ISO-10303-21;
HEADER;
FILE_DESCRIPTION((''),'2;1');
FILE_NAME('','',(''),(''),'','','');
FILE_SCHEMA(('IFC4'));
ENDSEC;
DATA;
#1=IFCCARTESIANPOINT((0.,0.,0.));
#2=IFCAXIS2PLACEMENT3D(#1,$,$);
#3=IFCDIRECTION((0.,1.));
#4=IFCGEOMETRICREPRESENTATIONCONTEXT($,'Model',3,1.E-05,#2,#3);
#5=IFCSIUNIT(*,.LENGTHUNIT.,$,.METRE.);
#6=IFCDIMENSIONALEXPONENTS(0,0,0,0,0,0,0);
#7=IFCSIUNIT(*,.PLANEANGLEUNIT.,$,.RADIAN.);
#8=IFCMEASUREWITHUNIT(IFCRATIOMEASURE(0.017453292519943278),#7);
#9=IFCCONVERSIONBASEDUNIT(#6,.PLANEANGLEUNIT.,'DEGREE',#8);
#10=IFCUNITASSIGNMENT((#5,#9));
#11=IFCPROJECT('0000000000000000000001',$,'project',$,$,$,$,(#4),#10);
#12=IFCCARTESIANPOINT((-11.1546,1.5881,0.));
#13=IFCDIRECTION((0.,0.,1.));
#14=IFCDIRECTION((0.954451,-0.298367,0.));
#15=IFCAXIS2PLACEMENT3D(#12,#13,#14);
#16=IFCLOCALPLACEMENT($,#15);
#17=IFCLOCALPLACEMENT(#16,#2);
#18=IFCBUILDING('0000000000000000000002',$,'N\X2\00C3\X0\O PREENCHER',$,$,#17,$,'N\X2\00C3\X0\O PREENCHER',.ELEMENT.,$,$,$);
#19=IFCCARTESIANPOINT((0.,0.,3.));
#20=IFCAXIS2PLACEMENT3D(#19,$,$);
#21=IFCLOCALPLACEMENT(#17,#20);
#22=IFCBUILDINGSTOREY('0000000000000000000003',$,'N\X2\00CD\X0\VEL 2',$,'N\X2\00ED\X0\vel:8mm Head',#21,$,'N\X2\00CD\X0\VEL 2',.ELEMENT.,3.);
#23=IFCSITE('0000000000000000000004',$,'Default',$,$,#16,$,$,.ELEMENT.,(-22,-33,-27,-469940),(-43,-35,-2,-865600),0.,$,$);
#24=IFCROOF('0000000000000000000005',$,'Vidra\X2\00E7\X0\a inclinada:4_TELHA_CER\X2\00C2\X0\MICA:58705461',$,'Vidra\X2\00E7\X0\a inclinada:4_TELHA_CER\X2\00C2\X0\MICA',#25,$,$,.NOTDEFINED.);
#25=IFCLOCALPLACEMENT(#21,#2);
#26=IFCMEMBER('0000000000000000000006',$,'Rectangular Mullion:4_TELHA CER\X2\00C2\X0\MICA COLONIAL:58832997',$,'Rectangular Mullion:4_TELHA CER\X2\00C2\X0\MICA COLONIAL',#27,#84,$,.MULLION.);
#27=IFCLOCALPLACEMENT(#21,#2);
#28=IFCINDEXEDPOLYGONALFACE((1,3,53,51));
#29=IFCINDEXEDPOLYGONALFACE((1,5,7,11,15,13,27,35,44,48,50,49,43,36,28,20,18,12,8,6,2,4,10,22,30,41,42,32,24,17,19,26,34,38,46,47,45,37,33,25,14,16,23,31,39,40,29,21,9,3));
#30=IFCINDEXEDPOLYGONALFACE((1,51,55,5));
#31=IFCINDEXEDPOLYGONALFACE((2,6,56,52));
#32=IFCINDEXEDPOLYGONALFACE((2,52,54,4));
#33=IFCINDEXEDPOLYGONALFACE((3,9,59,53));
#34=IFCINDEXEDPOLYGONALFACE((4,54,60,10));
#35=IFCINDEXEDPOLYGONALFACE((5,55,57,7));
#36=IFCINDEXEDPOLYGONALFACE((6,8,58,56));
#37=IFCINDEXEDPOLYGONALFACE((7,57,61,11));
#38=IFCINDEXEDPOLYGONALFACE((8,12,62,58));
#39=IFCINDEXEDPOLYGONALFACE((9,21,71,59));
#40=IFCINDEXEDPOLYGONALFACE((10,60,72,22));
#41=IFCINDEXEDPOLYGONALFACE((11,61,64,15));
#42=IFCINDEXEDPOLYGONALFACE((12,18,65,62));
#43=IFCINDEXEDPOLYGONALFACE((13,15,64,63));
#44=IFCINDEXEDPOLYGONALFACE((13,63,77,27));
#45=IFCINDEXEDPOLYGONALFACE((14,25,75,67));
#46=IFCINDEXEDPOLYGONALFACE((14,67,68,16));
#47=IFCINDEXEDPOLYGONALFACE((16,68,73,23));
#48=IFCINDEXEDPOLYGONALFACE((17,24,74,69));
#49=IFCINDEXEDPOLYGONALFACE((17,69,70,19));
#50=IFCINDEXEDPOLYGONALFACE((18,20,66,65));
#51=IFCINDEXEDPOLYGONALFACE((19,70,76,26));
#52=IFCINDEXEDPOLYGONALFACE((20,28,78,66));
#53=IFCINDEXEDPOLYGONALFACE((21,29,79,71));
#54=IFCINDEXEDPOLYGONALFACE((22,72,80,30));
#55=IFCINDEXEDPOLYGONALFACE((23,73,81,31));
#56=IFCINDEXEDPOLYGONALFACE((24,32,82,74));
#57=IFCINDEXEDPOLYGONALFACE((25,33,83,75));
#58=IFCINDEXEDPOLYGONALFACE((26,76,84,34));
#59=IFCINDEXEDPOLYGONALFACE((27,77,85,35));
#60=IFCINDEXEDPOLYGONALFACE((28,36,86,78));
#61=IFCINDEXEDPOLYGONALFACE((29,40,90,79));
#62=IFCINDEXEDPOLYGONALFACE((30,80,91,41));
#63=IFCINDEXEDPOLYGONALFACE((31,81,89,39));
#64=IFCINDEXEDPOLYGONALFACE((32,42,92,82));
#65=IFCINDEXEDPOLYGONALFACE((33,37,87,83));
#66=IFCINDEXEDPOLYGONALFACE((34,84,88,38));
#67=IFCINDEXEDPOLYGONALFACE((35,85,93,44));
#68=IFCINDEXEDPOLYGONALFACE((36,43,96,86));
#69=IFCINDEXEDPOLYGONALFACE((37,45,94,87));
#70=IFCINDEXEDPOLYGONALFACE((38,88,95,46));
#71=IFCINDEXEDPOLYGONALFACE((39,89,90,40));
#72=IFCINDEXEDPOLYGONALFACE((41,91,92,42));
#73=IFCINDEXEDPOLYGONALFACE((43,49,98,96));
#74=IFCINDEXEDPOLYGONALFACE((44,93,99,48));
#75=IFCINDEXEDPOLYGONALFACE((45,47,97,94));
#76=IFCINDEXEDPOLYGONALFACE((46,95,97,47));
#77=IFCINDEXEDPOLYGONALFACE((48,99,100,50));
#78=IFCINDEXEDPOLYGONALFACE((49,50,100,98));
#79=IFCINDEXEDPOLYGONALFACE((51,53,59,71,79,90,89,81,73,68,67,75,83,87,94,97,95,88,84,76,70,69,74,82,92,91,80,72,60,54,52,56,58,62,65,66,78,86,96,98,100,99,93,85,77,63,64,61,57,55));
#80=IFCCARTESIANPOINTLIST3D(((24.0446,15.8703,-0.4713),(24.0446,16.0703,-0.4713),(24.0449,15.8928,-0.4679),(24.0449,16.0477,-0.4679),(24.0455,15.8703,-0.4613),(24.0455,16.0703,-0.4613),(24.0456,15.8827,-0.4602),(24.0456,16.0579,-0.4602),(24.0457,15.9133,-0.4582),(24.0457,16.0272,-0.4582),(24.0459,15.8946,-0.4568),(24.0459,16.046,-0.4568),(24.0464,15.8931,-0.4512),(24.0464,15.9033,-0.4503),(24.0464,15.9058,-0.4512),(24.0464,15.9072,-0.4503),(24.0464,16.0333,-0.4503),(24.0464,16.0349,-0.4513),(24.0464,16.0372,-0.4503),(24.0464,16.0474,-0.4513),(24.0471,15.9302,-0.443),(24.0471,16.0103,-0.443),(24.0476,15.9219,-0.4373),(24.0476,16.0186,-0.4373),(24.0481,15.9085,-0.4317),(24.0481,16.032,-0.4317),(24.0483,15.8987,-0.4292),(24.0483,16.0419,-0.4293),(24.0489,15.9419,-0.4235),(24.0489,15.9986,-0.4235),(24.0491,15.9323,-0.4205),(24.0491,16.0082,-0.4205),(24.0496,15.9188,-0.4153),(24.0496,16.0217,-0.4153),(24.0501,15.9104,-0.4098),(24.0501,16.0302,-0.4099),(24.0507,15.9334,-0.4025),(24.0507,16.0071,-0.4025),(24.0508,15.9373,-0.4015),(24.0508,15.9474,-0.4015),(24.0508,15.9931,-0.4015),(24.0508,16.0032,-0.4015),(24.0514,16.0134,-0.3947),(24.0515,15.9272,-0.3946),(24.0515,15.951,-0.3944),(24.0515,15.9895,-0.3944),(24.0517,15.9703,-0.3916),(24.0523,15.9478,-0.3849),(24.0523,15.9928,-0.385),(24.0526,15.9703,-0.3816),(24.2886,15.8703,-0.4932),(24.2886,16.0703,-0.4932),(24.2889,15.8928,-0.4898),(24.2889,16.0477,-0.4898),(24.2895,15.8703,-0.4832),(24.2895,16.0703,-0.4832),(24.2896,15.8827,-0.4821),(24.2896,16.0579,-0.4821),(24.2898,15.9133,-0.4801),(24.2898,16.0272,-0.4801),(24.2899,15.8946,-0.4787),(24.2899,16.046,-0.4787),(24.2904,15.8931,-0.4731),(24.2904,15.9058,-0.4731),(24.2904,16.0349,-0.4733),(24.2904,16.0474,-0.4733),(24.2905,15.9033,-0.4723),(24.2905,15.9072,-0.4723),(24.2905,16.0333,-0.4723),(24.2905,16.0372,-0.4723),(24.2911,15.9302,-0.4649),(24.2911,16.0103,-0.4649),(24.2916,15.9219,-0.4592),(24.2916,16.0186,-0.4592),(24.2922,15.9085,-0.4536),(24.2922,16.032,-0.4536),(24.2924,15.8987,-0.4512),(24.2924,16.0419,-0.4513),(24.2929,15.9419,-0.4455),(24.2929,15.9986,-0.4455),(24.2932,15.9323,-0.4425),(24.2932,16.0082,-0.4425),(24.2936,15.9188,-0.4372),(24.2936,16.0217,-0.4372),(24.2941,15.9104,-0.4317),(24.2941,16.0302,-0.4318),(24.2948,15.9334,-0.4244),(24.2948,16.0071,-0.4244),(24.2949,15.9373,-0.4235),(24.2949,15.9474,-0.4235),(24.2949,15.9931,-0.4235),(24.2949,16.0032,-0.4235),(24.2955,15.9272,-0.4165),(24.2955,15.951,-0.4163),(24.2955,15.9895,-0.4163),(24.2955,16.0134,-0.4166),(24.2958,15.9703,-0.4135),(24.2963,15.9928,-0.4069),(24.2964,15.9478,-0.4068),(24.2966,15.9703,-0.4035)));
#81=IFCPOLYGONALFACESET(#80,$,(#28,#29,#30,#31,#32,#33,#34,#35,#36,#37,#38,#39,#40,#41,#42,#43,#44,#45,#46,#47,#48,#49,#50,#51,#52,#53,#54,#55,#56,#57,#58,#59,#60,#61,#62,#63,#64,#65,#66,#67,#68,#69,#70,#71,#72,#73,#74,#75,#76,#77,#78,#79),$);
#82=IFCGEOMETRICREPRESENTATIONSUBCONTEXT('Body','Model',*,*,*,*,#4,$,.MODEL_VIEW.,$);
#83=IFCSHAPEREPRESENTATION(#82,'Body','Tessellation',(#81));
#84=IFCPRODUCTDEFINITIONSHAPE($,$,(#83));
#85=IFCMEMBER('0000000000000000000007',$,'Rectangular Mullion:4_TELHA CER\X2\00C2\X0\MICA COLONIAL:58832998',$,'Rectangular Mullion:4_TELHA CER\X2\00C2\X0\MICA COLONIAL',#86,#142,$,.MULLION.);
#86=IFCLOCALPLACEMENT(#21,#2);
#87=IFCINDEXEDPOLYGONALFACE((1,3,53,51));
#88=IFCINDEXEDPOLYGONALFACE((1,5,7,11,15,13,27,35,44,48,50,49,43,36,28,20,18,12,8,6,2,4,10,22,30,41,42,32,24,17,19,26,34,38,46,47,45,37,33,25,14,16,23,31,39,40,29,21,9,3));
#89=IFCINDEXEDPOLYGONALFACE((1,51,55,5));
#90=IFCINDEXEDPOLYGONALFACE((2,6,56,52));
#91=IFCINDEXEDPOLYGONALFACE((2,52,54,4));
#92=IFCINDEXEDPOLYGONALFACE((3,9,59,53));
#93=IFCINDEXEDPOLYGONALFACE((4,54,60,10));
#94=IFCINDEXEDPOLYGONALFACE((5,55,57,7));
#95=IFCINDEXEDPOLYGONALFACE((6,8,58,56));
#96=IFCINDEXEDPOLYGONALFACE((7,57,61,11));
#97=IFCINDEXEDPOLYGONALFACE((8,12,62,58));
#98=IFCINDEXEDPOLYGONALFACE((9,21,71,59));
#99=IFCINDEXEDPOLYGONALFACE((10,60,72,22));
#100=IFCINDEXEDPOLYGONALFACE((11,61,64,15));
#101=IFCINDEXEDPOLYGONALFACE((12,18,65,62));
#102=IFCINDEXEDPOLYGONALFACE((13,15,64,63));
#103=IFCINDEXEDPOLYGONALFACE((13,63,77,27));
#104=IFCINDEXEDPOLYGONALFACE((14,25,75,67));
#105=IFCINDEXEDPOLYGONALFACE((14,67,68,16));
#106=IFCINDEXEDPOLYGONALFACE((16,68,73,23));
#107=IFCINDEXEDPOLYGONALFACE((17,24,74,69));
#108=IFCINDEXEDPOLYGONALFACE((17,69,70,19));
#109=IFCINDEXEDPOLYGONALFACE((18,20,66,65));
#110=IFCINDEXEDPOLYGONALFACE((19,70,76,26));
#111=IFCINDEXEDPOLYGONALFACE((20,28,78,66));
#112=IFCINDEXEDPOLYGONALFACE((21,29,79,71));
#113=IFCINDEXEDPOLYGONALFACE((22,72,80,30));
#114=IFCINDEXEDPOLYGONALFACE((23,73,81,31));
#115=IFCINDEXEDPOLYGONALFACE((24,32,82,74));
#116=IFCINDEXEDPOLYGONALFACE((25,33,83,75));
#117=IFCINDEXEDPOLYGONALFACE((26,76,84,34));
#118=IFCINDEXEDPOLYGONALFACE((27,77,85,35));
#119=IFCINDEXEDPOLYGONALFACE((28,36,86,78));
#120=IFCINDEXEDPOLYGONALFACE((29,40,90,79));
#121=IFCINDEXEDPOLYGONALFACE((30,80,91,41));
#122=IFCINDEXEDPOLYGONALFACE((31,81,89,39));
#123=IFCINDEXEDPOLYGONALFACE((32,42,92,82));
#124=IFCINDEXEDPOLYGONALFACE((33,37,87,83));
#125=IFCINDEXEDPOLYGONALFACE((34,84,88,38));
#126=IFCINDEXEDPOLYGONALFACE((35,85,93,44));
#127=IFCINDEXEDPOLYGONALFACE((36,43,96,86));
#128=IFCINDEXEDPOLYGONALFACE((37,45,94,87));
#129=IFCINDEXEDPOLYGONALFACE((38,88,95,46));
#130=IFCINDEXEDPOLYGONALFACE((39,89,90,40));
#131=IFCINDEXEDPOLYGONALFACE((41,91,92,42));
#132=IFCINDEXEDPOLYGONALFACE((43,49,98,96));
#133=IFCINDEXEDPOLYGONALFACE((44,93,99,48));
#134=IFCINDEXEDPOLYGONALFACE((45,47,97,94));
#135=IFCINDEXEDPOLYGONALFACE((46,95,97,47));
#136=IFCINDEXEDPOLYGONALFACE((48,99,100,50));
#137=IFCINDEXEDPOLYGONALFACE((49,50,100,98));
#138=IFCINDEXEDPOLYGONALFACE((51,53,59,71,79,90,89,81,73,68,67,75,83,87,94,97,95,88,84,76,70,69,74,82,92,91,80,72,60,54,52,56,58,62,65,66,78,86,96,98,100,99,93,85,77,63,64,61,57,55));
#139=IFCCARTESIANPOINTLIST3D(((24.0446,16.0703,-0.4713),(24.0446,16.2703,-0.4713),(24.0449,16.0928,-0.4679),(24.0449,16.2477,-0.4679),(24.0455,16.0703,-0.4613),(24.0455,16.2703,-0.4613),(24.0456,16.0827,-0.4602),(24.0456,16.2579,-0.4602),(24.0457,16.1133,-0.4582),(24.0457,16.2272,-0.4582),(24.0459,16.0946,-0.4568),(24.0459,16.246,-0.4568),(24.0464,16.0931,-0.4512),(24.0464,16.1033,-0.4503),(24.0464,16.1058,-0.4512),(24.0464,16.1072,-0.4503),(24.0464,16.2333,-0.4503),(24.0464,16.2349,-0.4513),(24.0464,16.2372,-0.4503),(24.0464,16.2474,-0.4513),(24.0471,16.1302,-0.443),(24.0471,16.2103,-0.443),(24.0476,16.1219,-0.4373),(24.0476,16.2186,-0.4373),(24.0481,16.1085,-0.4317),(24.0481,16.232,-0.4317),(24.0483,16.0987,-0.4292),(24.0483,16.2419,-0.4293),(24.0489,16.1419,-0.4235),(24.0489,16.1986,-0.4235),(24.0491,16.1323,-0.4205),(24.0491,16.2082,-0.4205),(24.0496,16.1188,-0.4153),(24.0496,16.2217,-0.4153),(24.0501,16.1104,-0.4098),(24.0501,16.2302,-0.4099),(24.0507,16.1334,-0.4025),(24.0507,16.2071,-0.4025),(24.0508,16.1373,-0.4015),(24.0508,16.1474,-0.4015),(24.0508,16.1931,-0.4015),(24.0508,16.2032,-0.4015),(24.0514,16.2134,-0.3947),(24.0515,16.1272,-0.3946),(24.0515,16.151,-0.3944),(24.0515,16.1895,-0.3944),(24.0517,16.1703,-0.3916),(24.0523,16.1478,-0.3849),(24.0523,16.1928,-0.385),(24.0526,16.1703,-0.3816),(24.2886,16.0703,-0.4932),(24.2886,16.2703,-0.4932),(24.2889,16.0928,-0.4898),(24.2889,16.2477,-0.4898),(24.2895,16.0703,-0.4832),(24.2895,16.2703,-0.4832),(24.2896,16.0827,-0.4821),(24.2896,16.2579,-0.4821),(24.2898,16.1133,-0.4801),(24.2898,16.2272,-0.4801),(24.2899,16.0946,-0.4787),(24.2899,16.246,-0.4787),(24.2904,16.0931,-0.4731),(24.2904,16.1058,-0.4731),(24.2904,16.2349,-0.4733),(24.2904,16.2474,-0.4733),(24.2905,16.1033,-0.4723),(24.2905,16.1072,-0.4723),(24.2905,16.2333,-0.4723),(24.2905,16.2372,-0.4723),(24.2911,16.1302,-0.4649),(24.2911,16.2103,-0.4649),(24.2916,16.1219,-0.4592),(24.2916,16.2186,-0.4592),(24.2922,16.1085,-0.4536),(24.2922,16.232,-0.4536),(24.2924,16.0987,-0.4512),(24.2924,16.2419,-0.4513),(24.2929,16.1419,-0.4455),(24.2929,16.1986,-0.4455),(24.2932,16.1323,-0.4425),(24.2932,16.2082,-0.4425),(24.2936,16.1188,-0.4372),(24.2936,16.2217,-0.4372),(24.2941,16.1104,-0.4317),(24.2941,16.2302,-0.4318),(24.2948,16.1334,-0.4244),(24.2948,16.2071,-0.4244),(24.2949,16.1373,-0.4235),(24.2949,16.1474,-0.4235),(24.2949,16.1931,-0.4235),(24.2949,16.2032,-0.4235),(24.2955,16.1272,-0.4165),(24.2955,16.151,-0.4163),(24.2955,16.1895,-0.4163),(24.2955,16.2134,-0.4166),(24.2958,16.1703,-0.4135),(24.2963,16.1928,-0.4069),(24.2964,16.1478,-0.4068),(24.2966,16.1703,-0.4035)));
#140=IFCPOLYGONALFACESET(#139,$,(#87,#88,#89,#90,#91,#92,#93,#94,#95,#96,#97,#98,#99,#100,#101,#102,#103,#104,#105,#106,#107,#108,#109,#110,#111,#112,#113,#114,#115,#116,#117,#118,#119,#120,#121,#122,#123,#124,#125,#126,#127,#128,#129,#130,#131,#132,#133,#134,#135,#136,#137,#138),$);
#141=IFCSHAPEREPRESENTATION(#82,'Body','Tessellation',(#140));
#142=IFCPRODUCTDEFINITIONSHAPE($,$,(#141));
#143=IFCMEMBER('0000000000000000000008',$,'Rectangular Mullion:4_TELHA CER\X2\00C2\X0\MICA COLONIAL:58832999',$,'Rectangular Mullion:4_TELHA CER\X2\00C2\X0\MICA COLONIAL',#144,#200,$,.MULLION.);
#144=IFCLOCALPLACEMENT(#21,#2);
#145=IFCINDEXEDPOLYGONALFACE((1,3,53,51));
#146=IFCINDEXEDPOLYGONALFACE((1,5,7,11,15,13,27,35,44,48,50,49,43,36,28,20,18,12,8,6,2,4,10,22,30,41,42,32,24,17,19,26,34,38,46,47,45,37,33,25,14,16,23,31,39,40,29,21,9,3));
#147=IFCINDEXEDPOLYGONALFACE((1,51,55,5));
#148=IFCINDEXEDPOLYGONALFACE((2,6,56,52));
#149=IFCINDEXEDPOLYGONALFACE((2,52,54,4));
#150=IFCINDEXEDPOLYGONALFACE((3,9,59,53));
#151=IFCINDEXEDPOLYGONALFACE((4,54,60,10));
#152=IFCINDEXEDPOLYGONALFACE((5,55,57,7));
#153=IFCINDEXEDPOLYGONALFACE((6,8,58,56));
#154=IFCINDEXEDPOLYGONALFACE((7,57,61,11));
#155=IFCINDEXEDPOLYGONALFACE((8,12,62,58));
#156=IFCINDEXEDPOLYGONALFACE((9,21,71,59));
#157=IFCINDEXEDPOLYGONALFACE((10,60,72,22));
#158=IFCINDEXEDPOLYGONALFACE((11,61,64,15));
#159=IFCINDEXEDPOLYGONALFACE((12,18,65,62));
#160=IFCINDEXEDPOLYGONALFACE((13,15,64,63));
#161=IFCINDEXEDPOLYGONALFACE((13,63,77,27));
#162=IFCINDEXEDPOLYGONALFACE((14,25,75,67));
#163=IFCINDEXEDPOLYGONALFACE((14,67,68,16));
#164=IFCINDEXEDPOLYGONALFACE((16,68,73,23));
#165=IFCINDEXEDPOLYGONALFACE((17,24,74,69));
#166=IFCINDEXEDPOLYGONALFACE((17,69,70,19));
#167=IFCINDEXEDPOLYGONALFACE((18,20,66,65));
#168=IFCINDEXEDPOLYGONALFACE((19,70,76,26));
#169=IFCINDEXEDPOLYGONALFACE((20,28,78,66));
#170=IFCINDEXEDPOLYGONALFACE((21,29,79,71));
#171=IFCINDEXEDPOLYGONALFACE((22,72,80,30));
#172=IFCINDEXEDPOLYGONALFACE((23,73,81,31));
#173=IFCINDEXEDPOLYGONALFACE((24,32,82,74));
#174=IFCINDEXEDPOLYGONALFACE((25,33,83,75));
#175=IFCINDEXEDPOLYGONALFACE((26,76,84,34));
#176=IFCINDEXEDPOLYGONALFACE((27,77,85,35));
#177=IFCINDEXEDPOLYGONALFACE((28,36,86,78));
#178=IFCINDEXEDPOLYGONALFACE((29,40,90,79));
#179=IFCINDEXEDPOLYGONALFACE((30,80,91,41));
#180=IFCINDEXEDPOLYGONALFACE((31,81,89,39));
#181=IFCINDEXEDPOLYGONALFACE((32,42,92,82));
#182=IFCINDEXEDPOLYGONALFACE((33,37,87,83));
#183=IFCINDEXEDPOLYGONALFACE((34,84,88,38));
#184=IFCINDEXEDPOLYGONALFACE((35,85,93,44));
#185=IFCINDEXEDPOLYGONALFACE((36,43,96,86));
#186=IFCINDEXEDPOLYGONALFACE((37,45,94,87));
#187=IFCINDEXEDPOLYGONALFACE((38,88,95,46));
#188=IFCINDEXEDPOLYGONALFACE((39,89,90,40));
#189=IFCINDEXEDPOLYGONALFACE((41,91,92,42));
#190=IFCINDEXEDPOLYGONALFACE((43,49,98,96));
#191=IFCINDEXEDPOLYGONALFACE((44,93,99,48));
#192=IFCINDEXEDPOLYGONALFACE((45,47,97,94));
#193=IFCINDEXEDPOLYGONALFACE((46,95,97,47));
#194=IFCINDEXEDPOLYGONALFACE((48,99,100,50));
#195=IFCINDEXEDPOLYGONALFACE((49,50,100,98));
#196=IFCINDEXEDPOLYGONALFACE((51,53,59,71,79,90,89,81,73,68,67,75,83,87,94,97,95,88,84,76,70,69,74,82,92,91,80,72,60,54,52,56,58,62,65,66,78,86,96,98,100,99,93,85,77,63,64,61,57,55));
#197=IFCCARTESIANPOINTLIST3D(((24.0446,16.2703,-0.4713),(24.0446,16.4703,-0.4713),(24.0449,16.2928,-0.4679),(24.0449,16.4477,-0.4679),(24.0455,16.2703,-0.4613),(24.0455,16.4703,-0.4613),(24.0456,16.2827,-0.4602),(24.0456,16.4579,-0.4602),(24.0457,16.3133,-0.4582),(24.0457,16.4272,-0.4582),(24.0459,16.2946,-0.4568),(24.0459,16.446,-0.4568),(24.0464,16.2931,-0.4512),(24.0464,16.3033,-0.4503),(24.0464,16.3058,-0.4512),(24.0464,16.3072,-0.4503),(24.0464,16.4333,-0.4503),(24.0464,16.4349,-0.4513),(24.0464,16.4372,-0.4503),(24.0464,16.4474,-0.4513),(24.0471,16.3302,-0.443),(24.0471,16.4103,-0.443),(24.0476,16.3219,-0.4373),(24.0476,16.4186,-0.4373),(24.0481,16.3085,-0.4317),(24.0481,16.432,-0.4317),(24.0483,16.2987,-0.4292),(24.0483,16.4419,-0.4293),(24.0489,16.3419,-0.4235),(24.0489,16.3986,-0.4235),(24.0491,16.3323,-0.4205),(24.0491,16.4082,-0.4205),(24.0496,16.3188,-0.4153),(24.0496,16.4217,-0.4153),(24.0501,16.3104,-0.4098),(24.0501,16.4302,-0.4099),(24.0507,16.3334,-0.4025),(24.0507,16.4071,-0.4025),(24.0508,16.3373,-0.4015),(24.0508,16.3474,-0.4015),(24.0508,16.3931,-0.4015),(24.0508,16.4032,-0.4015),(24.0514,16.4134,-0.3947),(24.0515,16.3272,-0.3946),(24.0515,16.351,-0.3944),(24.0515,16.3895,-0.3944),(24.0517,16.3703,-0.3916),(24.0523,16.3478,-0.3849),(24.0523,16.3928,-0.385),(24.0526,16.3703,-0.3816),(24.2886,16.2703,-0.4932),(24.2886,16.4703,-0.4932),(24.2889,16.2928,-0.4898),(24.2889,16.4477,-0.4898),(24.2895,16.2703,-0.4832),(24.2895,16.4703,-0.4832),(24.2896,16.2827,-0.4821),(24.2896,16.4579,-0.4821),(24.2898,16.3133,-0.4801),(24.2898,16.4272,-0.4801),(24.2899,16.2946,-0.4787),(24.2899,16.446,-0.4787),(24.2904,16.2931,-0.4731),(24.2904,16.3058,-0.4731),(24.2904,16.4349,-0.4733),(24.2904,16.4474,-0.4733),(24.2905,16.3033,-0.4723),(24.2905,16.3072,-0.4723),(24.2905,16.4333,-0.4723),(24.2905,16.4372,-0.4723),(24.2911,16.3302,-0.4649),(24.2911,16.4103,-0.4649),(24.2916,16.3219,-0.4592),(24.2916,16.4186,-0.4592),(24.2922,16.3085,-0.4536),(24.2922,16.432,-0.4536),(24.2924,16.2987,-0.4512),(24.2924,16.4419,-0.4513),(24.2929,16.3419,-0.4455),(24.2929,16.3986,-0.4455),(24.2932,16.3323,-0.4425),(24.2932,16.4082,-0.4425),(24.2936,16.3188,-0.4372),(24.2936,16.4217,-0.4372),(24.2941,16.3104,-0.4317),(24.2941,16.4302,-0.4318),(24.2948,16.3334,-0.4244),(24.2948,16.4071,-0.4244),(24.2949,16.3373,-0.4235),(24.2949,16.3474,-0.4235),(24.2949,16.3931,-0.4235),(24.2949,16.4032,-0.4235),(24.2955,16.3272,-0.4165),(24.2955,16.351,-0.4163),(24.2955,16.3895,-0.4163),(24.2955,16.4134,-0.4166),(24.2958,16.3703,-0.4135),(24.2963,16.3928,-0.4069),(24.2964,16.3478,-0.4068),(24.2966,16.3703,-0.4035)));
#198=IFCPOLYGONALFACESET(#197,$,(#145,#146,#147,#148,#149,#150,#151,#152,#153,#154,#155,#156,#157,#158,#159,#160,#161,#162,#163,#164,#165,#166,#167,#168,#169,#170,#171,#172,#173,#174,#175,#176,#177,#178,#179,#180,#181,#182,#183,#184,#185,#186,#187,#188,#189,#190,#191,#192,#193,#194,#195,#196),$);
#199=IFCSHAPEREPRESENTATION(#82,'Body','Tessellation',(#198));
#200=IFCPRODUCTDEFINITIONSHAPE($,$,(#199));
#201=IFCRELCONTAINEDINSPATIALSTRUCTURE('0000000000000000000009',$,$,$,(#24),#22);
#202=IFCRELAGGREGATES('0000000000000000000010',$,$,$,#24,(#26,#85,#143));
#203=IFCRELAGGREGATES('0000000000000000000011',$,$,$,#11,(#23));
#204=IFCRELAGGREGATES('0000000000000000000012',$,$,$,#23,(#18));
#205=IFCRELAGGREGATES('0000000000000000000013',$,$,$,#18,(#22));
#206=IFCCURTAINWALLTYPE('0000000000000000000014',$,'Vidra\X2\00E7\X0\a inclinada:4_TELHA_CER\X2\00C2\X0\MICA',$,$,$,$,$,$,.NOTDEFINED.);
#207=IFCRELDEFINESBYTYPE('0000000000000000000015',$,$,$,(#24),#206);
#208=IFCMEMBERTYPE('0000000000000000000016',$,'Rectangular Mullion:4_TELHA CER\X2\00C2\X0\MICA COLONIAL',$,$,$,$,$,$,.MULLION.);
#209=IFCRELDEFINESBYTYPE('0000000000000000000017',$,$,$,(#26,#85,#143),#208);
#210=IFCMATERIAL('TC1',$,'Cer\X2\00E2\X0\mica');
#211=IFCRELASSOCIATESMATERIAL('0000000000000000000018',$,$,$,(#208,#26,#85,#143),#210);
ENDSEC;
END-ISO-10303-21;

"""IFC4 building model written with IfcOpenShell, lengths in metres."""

from ifc_helpers import new_model, entity, si_unit, converted_unit, direction, frame, origin, place, context, subcontext, project, spatial, line, arc, indexed_curve, outline, extrude, source, transform, mapped, material, type_object, type_shapes, element, aggregate, save


model = new_model("IFC4")

# Units and contexts
model_context = context("Model", 3, precision=1e-05, world=origin(), true_north=direction((0.0, 1.0)))
body_context = subcontext(model_context, "Body", "Model", "MODEL_VIEW")
ifc_project = project(units=[si_unit("LENGTHUNIT", "METRE"), converted_unit("PLANEANGLEUNIT", "DEGREE", entity("IfcRatioMeasure", 0.017453292519943278), si_unit("PLANEANGLEUNIT", "RADIAN"), dimensions=[0, 0, 0, 0, 0, 0, 0])], contexts=[model_context])

# Site, building, storey
site_placement = place(None, frame((-11.1546, 1.5881, 0.0), z_axis=(0.0, 0.0, 1.0), x_axis=(0.954451, -0.298367, 0.0)))
site = spatial("IfcSite", under=ifc_project, at=site_placement, Name="Default", CompositionType="ELEMENT", RefLatitude=(-22, -33, -27, -469940), RefLongitude=(-43, -35, -2, -865600), RefElevation=0.0)
building_placement = place(site_placement, origin())
building = spatial("IfcBuilding", under=site, at=building_placement, Name="NÃO PREENCHER", LongName="NÃO PREENCHER", CompositionType="ELEMENT")
storey_placement = place(building_placement, frame((0.0, 0.0, 3.0)))
storey = spatial("IfcBuildingStorey", under=building, at=storey_placement, Name="NÍVEL 2", ObjectType="Nível:8mm Head", LongName="NÍVEL 2", CompositionType="ELEMENT", Elevation=3.0)

# Roof, members
curtain_wall_type = type_object("IfcCurtainWallType", Name="Vidraça inclinada:4_TELHA_CERÂMICA", PredefinedType="NOTDEFINED")
roof_placement = place(storey_placement, frame((0.0, 0.0, -3.0)))
roof = element("IfcRoof", 1, at=roof_placement, inside=storey, type_object=curtain_wall_type, Name="Vidraça inclinada:4_TELHA_CERÂMICA:58705461", ObjectType="Vidraça inclinada:4_TELHA_CERÂMICA", PredefinedType="NOTDEFINED")
ifc_material_1 = material(Name="TC1", Category="Cerâmica")
member_type_1 = type_object("IfcMemberType", Name="Rectangular Mullion:4_TELHA CERÂMICA COLONIAL", PredefinedType="MULLION", material=ifc_material_1)
shared_shape_1 = source(origin(), body_context, "Body", "SweptSolid", [
    extrude(outline(indexed_curve([(-0.029, -0.1), (-0.019, -0.1), (-0.0164, -0.0815), (-0.0089, -0.0645), (-0.0089, -0.0771), (0.061, 0.0), (-0.009, 0.0771), (-0.009, 0.0646), (-0.0165, 0.0816), (-0.019, 0.1), (-0.029, 0.1), (-0.0089, 0.0479), (0.041, 0.0229), (0.041, 0.0329), (0.0131, 0.0425), (-0.008, 0.0631), (-0.008, 0.067), (0.051, 0.0), (-0.008, -0.067), (-0.008, -0.0631), (0.0131, -0.0425), (0.041, -0.0329), (0.041, -0.0229), (-0.0089, -0.0479)], segments=[line(1, 2), arc(2, 3, 4), line(4, 5), arc(5, 6, 7), line(7, 8), arc(8, 9, 10), line(10, 11), arc(11, 12, 13), line(13, 14), arc(14, 15, 16), line(16, 17), arc(17, 18, 19), line(19, 20), arc(20, 21, 22), line(22, 23), arc(23, 24, 1)], self_intersect=False)), frame((0.0, -0.029, -0.245), z_axis=(0.0, 0.0, 1.0), x_axis=(0.0, -1.0, 0.0)), (0.0, 0.0, 1.0), 0.245),
])
type_shapes(member_type_1, [shared_shape_1])
member_1_placement = place(roof_placement, frame((24.0446, 15.9703, 2.5287), z_axis=(-0.99599, 0.0, 0.089469), x_axis=(0.0, 1.0, 0.0)))
member_1 = element("IfcMember", 2, at=member_1_placement, type_object=member_type_1, material=ifc_material_1, Name="Rectangular Mullion:4_TELHA CERÂMICA COLONIAL:58832997", ObjectType="Rectangular Mullion:4_TELHA CERÂMICA COLONIAL", PredefinedType="MULLION", context=body_context, shape_type="MappedRepresentation", body=[
    mapped(shared_shape_1, transform((0.0, 0.0, 0.0), scale=1.0)),
])
member_2_placement = place(roof_placement, frame((24.0446, 16.1703, 2.5287), z_axis=(-0.99599, 0.0, 0.089469), x_axis=(0.0, 1.0, 0.0)))
member_2 = element("IfcMember", 3, at=member_2_placement, type_object=member_type_1, material=ifc_material_1, Name="Rectangular Mullion:4_TELHA CERÂMICA COLONIAL:58832998", ObjectType="Rectangular Mullion:4_TELHA CERÂMICA COLONIAL", PredefinedType="MULLION", context=body_context, shape_type="MappedRepresentation", body=[
    mapped(shared_shape_1, transform((0.0, 0.0, 0.0), scale=1.0)),
])
member_3_placement = place(roof_placement, frame((24.0446, 16.3703, 2.5287), z_axis=(-0.99599, 0.0, 0.089469), x_axis=(0.0, 1.0, 0.0)))
member_3 = element("IfcMember", 4, at=member_3_placement, type_object=member_type_1, material=ifc_material_1, Name="Rectangular Mullion:4_TELHA CERÂMICA COLONIAL:58832999", ObjectType="Rectangular Mullion:4_TELHA CERÂMICA COLONIAL", PredefinedType="MULLION", context=body_context, shape_type="MappedRepresentation", body=[
    mapped(shared_shape_1, transform((0.0, 0.0, 0.0), scale=1.0)),
])
aggregate(roof, [member_1, member_2, member_3])

save(model, "model.ifc")
